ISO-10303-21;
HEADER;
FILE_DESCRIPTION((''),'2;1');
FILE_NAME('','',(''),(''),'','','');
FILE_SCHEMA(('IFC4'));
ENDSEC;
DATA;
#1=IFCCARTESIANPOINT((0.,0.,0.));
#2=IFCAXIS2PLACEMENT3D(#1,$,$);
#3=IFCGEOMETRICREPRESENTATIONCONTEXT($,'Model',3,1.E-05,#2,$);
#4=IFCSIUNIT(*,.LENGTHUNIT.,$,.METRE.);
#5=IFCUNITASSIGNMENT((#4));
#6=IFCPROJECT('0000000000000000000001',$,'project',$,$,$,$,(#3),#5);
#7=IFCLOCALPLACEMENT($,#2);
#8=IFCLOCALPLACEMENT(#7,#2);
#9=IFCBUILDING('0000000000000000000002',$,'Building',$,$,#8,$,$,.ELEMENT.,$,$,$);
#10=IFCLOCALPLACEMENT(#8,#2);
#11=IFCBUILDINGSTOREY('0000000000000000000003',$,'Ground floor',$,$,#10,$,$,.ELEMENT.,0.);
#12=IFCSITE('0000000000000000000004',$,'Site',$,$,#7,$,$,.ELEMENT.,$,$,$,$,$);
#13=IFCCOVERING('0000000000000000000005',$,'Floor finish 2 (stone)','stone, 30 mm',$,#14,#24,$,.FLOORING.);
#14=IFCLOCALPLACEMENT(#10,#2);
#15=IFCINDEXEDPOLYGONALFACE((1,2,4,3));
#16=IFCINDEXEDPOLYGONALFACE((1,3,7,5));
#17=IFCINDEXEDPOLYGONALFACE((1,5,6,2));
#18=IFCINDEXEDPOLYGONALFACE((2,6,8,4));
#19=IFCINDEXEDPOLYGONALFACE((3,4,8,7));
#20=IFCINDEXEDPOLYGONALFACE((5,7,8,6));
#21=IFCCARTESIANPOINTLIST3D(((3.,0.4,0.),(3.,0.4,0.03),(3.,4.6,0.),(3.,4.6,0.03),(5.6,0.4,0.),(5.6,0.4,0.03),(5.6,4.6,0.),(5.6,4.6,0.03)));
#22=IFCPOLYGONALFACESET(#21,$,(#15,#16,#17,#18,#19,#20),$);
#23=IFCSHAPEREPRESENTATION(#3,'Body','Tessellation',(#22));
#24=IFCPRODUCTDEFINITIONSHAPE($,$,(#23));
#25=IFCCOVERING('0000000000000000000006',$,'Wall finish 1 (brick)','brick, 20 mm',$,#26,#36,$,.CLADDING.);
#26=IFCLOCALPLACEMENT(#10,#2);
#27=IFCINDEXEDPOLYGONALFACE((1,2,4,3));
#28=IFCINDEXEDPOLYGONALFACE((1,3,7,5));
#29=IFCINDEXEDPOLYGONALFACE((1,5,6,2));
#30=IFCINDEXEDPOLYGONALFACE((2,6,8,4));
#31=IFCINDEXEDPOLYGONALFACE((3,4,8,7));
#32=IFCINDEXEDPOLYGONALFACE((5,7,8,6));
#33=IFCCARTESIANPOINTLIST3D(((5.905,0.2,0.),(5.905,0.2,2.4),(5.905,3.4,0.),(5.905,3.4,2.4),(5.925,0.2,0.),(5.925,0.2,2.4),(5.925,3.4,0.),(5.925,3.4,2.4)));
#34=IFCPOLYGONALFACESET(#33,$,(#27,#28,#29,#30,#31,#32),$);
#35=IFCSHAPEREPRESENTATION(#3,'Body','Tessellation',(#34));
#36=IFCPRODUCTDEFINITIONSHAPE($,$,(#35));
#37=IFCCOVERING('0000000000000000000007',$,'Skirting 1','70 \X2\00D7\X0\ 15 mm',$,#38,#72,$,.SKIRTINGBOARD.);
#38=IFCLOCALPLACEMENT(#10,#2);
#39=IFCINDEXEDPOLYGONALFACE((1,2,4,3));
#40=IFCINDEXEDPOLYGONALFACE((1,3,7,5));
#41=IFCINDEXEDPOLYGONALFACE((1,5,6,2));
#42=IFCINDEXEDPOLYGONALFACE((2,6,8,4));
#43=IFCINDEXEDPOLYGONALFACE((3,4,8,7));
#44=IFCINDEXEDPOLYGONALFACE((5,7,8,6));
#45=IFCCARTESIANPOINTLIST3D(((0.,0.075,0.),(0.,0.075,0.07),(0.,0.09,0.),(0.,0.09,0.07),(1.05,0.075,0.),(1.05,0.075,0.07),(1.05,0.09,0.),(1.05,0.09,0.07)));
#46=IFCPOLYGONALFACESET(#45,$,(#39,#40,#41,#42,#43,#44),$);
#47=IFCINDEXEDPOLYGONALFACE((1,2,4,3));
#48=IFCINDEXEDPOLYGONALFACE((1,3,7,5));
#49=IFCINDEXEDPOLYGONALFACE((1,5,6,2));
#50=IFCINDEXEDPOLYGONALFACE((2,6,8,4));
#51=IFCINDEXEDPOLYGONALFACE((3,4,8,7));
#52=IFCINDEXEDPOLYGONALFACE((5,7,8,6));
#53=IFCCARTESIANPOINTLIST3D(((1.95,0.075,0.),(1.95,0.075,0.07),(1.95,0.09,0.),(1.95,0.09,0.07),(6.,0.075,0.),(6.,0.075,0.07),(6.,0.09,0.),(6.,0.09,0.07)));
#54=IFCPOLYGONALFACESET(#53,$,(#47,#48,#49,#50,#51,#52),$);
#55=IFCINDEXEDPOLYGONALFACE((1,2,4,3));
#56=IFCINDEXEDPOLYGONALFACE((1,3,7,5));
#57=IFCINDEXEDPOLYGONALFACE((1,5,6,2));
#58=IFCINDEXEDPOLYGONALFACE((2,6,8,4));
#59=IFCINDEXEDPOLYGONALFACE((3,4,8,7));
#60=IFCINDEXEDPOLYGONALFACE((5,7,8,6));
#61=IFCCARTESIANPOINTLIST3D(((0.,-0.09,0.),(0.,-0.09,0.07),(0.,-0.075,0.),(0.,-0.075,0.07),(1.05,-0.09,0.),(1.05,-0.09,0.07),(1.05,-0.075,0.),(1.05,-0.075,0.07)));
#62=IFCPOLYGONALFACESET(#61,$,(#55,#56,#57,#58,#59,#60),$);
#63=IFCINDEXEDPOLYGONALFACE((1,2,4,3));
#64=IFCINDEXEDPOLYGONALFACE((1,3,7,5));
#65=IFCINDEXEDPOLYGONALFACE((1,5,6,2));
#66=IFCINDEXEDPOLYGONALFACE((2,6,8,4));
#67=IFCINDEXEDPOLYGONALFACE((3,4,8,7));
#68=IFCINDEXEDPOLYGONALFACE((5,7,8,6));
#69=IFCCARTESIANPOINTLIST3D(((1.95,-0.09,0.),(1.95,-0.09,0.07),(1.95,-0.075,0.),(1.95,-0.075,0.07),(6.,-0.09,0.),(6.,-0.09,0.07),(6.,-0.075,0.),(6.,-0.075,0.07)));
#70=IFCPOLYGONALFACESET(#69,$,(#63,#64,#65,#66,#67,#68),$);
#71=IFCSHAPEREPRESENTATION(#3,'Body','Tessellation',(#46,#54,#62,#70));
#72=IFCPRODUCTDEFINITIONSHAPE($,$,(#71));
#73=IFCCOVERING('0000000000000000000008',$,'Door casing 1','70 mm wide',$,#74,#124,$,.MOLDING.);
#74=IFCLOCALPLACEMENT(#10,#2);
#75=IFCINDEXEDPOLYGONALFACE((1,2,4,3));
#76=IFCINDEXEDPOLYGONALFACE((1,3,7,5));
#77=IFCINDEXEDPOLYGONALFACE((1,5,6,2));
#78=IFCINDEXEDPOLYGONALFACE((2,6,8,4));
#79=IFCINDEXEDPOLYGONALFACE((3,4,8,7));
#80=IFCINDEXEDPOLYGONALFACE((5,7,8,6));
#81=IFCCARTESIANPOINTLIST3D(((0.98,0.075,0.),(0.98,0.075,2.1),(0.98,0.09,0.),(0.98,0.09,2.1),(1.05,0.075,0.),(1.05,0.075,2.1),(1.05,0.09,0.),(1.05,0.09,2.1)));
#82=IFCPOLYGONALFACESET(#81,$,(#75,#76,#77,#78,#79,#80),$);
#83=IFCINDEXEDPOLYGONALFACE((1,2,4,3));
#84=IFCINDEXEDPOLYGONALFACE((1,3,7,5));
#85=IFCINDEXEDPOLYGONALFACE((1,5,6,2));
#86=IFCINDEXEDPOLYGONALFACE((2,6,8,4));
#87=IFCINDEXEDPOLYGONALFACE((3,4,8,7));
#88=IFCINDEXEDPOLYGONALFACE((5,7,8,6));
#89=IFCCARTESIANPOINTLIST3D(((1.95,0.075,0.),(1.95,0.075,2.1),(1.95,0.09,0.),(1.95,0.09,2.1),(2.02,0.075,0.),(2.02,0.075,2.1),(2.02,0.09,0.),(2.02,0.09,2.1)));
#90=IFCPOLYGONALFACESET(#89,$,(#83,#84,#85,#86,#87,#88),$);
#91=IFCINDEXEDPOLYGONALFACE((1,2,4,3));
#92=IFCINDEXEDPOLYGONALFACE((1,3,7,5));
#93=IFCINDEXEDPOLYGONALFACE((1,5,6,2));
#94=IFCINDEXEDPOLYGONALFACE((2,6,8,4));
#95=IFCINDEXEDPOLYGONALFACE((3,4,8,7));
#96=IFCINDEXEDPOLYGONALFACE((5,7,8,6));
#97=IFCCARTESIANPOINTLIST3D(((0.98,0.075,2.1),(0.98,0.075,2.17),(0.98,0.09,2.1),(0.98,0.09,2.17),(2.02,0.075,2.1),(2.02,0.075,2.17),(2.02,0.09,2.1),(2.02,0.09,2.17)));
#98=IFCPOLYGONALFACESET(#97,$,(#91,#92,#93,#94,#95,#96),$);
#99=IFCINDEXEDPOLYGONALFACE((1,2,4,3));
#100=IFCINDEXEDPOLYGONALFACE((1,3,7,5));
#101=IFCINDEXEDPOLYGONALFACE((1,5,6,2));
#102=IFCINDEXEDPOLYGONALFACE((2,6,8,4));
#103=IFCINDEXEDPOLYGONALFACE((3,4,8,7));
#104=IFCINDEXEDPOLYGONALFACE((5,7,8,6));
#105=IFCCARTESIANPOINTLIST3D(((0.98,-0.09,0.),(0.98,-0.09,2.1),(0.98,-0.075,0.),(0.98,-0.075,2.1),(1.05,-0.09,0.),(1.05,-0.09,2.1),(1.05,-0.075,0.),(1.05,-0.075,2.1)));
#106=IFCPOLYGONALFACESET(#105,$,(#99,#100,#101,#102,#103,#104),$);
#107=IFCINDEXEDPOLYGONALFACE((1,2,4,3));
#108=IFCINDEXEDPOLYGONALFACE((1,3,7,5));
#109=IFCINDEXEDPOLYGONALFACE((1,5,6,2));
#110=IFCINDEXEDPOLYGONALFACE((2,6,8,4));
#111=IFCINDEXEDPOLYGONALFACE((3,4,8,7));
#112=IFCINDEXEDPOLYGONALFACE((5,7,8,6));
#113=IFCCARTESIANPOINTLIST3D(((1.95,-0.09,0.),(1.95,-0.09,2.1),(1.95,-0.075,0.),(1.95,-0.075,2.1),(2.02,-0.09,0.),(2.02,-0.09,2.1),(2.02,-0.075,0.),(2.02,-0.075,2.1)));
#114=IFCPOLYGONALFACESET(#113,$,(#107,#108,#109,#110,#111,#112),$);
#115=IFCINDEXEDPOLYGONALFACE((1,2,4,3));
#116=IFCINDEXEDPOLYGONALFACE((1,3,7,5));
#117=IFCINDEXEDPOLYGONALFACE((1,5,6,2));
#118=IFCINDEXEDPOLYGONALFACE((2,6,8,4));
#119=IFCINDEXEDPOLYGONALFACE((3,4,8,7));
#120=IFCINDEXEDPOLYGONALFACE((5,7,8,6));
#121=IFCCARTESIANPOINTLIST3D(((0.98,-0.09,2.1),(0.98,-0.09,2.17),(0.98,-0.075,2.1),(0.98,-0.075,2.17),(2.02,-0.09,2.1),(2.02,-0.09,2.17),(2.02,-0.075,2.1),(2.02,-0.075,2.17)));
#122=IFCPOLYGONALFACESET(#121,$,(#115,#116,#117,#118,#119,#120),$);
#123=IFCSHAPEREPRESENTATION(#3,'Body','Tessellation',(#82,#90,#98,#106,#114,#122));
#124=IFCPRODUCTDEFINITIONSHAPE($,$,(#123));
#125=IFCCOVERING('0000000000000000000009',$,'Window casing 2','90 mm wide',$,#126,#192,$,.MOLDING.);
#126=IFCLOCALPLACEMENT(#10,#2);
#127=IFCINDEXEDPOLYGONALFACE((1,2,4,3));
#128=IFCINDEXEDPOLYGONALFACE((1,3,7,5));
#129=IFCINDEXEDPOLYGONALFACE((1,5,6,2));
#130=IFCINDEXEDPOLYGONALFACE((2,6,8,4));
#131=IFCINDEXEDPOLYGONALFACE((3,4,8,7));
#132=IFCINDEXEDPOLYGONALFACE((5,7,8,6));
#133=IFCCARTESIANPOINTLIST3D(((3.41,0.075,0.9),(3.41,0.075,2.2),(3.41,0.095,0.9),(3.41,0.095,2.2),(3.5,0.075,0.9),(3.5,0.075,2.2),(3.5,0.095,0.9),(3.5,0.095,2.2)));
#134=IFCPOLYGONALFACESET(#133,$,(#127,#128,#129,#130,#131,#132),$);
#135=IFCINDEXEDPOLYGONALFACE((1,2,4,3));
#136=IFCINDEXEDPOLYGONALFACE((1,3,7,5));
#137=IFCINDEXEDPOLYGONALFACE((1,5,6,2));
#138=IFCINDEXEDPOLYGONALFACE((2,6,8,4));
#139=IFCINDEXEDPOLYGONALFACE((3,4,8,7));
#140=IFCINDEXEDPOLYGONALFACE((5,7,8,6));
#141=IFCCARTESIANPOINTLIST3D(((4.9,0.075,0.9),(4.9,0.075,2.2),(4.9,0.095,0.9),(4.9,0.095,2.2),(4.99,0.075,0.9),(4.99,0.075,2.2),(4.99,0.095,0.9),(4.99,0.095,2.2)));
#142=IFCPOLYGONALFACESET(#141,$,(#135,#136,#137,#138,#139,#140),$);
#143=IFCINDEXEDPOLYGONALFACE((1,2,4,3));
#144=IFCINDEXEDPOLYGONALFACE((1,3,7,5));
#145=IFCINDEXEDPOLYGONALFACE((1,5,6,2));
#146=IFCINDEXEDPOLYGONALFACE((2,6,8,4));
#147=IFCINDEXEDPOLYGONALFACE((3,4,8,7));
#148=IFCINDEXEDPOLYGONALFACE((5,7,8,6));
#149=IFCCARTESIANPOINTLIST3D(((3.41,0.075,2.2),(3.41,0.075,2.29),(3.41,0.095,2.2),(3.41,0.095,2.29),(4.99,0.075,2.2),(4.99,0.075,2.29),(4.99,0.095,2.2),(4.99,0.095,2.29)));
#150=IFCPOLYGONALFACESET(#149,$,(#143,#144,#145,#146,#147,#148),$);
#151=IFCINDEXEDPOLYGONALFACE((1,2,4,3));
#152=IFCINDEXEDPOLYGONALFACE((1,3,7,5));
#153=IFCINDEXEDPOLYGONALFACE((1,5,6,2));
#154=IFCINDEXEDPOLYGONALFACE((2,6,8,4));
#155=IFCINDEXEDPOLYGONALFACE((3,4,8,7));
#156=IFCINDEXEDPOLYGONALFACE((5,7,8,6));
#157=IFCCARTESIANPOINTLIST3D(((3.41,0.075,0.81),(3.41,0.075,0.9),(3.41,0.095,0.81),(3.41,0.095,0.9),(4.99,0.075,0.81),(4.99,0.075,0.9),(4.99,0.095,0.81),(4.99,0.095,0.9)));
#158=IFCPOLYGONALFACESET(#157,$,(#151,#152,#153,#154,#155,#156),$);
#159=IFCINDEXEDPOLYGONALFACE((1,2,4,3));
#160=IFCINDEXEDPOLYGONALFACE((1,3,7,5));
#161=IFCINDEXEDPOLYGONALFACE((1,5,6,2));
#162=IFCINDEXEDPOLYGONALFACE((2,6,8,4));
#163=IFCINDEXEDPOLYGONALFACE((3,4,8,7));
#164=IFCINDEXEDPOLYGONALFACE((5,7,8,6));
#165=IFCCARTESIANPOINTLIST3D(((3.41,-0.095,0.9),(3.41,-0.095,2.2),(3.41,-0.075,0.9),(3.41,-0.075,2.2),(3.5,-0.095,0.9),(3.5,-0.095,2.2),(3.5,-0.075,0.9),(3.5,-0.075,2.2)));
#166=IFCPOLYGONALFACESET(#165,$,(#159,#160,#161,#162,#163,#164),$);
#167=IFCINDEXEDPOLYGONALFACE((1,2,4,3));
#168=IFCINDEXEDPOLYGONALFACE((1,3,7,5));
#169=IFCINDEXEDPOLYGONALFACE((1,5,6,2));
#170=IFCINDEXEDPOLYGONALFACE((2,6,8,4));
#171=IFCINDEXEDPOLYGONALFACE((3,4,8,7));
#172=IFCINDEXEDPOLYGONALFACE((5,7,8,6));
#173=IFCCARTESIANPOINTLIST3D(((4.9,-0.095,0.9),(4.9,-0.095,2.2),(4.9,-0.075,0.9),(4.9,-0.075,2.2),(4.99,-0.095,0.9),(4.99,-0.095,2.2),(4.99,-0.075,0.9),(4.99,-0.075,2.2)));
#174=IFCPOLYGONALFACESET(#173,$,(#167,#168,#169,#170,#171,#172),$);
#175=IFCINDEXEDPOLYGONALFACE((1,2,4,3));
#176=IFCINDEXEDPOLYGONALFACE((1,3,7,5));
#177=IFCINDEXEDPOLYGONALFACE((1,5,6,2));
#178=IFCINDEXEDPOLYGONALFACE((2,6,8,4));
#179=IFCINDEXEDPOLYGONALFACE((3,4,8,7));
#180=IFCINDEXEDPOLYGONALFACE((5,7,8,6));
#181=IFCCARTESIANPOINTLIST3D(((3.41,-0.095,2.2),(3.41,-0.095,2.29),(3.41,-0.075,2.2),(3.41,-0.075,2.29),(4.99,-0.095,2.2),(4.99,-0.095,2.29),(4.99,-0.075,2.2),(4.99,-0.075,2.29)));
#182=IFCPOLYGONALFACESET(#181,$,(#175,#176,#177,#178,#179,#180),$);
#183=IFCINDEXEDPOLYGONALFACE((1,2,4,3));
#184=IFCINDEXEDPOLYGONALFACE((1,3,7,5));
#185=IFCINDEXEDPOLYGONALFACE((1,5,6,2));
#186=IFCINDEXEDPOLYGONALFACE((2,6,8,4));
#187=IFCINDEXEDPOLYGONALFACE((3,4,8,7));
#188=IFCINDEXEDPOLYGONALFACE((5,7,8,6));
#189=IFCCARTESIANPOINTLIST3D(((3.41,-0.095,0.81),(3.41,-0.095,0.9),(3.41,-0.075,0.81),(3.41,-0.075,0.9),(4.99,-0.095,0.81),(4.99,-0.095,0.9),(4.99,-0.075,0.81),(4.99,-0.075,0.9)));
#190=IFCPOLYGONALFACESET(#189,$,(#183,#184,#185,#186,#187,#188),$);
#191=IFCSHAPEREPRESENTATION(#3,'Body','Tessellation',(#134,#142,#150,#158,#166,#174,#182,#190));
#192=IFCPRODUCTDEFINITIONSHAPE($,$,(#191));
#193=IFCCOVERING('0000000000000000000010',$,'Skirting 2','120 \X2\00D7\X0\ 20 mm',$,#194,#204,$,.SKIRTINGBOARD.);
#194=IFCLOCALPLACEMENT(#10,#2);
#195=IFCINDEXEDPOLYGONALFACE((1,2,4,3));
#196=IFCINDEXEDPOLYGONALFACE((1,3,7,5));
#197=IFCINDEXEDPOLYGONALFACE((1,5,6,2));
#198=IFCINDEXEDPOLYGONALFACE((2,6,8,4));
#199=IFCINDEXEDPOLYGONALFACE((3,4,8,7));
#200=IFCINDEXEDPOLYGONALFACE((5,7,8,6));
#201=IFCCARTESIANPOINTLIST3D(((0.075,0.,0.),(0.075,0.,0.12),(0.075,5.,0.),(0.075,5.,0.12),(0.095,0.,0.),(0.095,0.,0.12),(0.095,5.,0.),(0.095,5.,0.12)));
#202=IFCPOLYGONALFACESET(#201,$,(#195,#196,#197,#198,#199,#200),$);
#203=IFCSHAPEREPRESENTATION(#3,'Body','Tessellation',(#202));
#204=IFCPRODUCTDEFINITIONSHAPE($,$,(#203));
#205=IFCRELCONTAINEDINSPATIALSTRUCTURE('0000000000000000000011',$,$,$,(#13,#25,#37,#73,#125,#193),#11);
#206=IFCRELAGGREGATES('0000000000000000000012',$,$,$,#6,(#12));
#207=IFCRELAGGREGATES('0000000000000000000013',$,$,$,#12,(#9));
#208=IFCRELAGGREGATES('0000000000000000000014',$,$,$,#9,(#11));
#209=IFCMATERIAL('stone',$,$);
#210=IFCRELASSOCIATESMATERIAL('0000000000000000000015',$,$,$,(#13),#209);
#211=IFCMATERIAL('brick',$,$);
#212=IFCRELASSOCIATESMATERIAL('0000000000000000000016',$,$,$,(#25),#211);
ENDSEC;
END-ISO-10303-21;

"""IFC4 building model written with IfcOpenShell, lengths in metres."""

from ifc_helpers import new_model, si_unit, frame, origin, origin_with_axes, place, context, project, spatial, polyline, outline, extrude, material, element, save


model = new_model("IFC4")

# Units and contexts
model_context = context("Model", 3, precision=1e-05, world=origin())
ifc_project = project(units=[si_unit("LENGTHUNIT", "METRE")], contexts=[model_context])

# Site, building, storey
site_placement = place(None, origin())
site = spatial("IfcSite", under=ifc_project, at=site_placement, Name="Site", CompositionType="ELEMENT")
building_placement = place(site_placement, origin())
building = spatial("IfcBuilding", under=site, at=building_placement, Name="Building", CompositionType="ELEMENT")
storey_placement = place(building_placement, origin())
storey = spatial("IfcBuildingStorey", under=building, at=storey_placement, Name="Ground floor", CompositionType="ELEMENT", Elevation=0.0)

# Shared definitions
ifc_material_1 = material(Name="brick")

# Shared definitions
ifc_material_2 = material(Name="stone")

# Coverings
covering_1_placement = place(storey_placement, origin_with_axes())
element("IfcCovering", 1, at=covering_1_placement, inside=storey, material=ifc_material_2, Name="Floor finish 2 (stone)", Description="stone, 30 mm", PredefinedType="FLOORING", context=model_context, shape_type="SweptSolid", body=[
    extrude(outline(polyline([(3.0, 0.4), (5.6, 0.4), (5.6, 4.6), (3.0, 4.6), (3.0, 0.4)])), origin(), (0.0, 0.0, 1.0), 0.03),
])
covering_2_placement = place(storey_placement, origin_with_axes())
element("IfcCovering", 2, at=covering_2_placement, inside=storey, material=ifc_material_1, Name="Wall finish 1 (brick)", Description="brick, 20 mm", PredefinedType="CLADDING", context=model_context, shape_type="SweptSolid", body=[
    extrude(outline(polyline([(5.925, 0.2), (5.925, 3.4), (5.905, 3.4), (5.905, 0.2), (5.925, 0.2)])), origin(), (0.0, 0.0, 1.0), 2.4),
])
placement = place(storey_placement, origin_with_axes())
element("IfcCovering", 3, at=placement, inside=storey, Name="Skirting 1", Description="70 × 15 mm", PredefinedType="SKIRTINGBOARD", context=model_context, shape_type="SweptSolid", body=[
    extrude(outline(polyline([(0.0, 0.075), (1.05, 0.075), (1.05, 0.09), (0.0, 0.09), (0.0, 0.075)])), origin(), (0.0, 0.0, 1.0), 0.07),
    extrude(outline(polyline([(1.95, 0.075), (6.0, 0.075), (6.0, 0.09), (1.95, 0.09), (1.95, 0.075)])), origin(), (0.0, 0.0, 1.0), 0.07),
    extrude(outline(polyline([(0.0, -0.09), (1.05, -0.09), (1.05, -0.075), (0.0, -0.075), (0.0, -0.09)])), origin(), (0.0, 0.0, 1.0), 0.07),
    extrude(outline(polyline([(1.95, -0.09), (6.0, -0.09), (6.0, -0.075), (1.95, -0.075), (1.95, -0.09)])), origin(), (0.0, 0.0, 1.0), 0.07),
])
element("IfcCovering", 4, at=placement, inside=storey, Name="Door casing 1", Description="70 mm wide", PredefinedType="MOLDING", context=model_context, shape_type="SweptSolid", body=[
    extrude(outline(polyline([(0.98, 0.075), (1.05, 0.075), (1.05, 0.09), (0.98, 0.09), (0.98, 0.075)])), origin(), (0.0, 0.0, 1.0), 2.1),
    extrude(outline(polyline([(1.95, 0.075), (2.02, 0.075), (2.02, 0.09), (1.95, 0.09), (1.95, 0.075)])), origin(), (0.0, 0.0, 1.0), 2.1),
    extrude(outline(polyline([(0.98, 0.075), (2.02, 0.075), (2.02, 0.09), (0.98, 0.09), (0.98, 0.075)])), frame((0.0, 0.0, 2.1)), (0.0, 0.0, 1.0), 0.07),
    extrude(outline(polyline([(0.98, -0.09), (1.05, -0.09), (1.05, -0.075), (0.98, -0.075), (0.98, -0.09)])), origin(), (0.0, 0.0, 1.0), 2.1),
    extrude(outline(polyline([(1.95, -0.09), (2.02, -0.09), (2.02, -0.075), (1.95, -0.075), (1.95, -0.09)])), origin(), (0.0, 0.0, 1.0), 2.1),
    extrude(outline(polyline([(0.98, -0.09), (2.02, -0.09), (2.02, -0.075), (0.98, -0.075), (0.98, -0.09)])), frame((0.0, 0.0, 2.1)), (0.0, 0.0, 1.0), 0.07),
])
element("IfcCovering", 5, at=placement, inside=storey, Name="Window casing 2", Description="90 mm wide", PredefinedType="MOLDING", context=model_context, shape_type="SweptSolid", body=[
    extrude(outline(polyline([(3.41, 0.075), (3.5, 0.075), (3.5, 0.095), (3.41, 0.095), (3.41, 0.075)])), frame((0.0, 0.0, 0.9)), (0.0, 0.0, 1.0), 1.3),
    extrude(outline(polyline([(4.9, 0.075), (4.99, 0.075), (4.99, 0.095), (4.9, 0.095), (4.9, 0.075)])), frame((0.0, 0.0, 0.9)), (0.0, 0.0, 1.0), 1.3),
    extrude(outline(polyline([(3.41, 0.075), (4.99, 0.075), (4.99, 0.095), (3.41, 0.095), (3.41, 0.075)])), frame((0.0, 0.0, 2.2)), (0.0, 0.0, 1.0), 0.09),
    extrude(outline(polyline([(3.41, 0.075), (4.99, 0.075), (4.99, 0.095), (3.41, 0.095), (3.41, 0.075)])), frame((0.0, 0.0, 0.81)), (0.0, 0.0, 1.0), 0.09),
    extrude(outline(polyline([(3.41, -0.095), (3.5, -0.095), (3.5, -0.075), (3.41, -0.075), (3.41, -0.095)])), frame((0.0, 0.0, 0.9)), (0.0, 0.0, 1.0), 1.3),
    extrude(outline(polyline([(4.9, -0.095), (4.99, -0.095), (4.99, -0.075), (4.9, -0.075), (4.9, -0.095)])), frame((0.0, 0.0, 0.9)), (0.0, 0.0, 1.0), 1.3),
    extrude(outline(polyline([(3.41, -0.095), (4.99, -0.095), (4.99, -0.075), (3.41, -0.075), (3.41, -0.095)])), frame((0.0, 0.0, 2.2)), (0.0, 0.0, 1.0), 0.09),
    extrude(outline(polyline([(3.41, -0.095), (4.99, -0.095), (4.99, -0.075), (3.41, -0.075), (3.41, -0.095)])), frame((0.0, 0.0, 0.81)), (0.0, 0.0, 1.0), 0.09),
])
covering_3_placement = place(storey_placement, origin_with_axes())
element("IfcCovering", 6, at=covering_3_placement, inside=storey, Name="Skirting 2", Description="120 × 20 mm", PredefinedType="SKIRTINGBOARD", context=model_context, shape_type="SweptSolid", body=[
    extrude(outline(polyline([(0.075, 5.0), (0.075, 0.0), (0.095, 0.0), (0.095, 5.0), (0.075, 5.0)])), origin(), (0.0, 0.0, 1.0), 0.12),
])

save(model, "model.ifc")
